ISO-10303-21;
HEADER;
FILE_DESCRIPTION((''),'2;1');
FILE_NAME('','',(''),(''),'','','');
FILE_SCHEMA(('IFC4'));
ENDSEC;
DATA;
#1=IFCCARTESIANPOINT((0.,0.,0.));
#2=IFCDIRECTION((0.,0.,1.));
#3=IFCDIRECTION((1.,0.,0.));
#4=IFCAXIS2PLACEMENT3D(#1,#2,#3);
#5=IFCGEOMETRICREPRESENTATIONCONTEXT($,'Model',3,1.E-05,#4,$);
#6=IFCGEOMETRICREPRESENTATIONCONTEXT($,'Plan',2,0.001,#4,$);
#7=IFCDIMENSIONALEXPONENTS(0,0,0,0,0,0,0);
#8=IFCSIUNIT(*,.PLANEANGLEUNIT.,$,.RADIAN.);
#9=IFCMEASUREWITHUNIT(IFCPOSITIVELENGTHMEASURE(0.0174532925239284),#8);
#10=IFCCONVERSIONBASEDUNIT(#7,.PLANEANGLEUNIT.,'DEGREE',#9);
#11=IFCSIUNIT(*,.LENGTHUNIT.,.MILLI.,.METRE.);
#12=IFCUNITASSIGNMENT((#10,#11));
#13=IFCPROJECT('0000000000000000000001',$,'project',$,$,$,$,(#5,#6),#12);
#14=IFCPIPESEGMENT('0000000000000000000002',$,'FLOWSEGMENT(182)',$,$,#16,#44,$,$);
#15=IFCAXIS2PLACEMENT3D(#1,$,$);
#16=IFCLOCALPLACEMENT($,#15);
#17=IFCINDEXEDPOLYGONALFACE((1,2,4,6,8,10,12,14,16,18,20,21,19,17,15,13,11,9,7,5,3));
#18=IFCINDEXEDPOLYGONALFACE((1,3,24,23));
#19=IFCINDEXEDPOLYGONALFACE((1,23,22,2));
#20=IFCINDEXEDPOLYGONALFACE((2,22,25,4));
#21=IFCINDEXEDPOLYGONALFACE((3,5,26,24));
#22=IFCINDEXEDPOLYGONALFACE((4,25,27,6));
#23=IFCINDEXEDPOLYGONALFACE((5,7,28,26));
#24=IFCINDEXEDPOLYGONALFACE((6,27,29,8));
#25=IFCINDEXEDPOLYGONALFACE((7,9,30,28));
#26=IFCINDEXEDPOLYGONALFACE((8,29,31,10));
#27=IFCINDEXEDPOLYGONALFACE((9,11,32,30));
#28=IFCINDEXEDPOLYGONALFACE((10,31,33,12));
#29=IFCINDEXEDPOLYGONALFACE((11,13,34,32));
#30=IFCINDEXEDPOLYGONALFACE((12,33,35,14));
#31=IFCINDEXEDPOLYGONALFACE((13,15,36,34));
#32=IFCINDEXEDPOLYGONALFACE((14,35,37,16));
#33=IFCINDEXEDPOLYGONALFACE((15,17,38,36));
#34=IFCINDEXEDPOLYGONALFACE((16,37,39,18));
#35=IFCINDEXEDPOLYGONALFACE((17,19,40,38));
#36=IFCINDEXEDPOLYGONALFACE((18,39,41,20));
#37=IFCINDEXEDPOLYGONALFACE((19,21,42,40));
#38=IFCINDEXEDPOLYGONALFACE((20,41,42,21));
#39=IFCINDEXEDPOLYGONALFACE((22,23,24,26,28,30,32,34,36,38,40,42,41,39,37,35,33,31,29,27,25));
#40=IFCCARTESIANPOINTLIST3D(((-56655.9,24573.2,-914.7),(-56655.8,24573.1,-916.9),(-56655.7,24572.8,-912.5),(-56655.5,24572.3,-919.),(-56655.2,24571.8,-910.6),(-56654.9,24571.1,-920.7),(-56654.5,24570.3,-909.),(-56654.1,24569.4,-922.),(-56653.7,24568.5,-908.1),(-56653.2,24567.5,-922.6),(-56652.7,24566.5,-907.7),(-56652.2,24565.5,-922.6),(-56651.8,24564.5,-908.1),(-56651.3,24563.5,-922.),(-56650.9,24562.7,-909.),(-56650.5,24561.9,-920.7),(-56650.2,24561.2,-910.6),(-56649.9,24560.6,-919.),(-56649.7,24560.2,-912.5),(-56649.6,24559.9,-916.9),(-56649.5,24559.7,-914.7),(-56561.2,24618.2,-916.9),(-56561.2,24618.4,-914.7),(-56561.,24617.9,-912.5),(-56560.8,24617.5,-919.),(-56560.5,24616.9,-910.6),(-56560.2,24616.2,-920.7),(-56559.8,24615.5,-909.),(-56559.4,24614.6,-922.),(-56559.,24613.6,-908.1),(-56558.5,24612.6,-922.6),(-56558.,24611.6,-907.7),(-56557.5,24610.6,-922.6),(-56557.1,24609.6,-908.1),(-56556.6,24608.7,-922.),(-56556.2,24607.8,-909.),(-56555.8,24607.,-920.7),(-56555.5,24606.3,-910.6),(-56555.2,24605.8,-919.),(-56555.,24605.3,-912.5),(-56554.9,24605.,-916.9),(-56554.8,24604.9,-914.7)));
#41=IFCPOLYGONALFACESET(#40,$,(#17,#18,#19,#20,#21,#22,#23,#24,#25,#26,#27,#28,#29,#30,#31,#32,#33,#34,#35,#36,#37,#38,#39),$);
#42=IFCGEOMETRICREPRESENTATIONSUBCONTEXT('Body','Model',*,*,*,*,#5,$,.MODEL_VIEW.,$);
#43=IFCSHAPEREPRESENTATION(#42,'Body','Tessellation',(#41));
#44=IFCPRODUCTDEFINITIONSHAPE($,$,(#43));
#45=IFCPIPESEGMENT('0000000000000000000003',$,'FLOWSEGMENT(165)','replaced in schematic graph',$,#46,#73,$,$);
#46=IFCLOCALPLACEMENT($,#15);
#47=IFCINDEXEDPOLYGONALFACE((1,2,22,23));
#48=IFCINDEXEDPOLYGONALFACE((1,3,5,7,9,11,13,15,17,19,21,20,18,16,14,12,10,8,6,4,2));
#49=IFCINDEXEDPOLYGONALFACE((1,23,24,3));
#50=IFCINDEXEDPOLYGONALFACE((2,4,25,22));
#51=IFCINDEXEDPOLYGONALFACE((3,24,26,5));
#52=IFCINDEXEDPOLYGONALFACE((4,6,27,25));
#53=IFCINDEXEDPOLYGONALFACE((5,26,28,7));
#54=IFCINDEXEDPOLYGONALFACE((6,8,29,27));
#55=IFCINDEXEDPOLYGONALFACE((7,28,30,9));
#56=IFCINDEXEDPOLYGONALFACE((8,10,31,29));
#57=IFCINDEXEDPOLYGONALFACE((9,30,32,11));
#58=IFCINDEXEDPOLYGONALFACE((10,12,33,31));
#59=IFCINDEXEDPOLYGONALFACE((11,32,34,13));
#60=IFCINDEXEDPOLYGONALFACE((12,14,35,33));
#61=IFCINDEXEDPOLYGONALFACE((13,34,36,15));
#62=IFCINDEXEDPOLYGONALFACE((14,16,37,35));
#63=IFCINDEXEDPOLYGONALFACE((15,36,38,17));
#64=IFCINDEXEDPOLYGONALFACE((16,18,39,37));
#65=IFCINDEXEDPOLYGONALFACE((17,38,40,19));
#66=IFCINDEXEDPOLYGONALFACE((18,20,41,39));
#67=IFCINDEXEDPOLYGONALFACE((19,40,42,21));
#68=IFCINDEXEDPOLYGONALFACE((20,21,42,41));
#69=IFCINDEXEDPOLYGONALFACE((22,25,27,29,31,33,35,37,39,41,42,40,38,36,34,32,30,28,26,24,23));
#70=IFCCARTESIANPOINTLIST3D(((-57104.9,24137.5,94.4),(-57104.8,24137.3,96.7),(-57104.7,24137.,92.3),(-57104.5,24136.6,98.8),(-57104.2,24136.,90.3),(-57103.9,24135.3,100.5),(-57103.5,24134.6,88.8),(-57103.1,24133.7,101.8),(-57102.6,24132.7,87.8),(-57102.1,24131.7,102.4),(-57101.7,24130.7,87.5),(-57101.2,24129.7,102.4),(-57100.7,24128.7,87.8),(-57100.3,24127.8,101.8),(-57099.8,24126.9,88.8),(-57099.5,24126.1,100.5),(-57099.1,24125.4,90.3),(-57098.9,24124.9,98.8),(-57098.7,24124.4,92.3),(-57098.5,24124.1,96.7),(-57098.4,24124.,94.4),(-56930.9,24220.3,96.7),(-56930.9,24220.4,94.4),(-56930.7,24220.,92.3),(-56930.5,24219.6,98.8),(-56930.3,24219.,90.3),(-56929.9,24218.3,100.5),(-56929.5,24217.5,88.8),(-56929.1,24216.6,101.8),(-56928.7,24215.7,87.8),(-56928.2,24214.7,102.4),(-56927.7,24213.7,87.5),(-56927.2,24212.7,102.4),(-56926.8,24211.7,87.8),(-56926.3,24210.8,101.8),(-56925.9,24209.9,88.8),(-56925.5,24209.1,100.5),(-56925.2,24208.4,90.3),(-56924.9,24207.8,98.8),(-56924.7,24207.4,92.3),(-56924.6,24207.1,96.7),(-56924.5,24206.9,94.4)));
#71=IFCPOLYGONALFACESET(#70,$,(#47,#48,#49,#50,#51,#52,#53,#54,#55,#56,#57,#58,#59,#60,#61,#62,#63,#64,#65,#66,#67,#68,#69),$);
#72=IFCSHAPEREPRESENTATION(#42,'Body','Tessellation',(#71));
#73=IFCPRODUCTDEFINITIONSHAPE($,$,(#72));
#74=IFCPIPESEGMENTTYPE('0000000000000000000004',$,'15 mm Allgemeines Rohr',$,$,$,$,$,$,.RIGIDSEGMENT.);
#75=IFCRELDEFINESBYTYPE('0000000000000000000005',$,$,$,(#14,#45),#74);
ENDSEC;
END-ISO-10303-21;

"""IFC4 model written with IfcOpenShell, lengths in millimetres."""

from ifc_helpers import new_model, entity, si_unit, converted_unit, frame, frame_2d, origin, origin_with_axes, place, context, subcontext, project, circle, extrude, source, transform, mapped, type_object, element, save


model = new_model("IFC4")

# Units and contexts
model_context = context("Model", 3, precision=1e-05, world=origin_with_axes())
plan_context = context("Plan", 2, precision=0.001, world=origin_with_axes())
body_context = subcontext(model_context, "Body", "Model", "MODEL_VIEW")
ifc_project = project(units=[converted_unit("PLANEANGLEUNIT", "DEGREE", entity("IfcPositiveLengthMeasure", 0.0174532925239284), si_unit("PLANEANGLEUNIT", "RADIAN"), dimensions=[0, 0, 0, 0, 0, 0, 0]), si_unit("LENGTHUNIT", "METRE", prefix="MILLI")], contexts=[model_context, plan_context])

# Pipe segments
pipe_segment_type_1 = type_object("IfcPipeSegmentType", Name="15 mm Allgemeines Rohr", PredefinedType="RIGIDSEGMENT")
shared_shape = source(origin(), body_context, "Body", "SweptSolid", [
    extrude(circle(Radius=7.5, at=frame_2d((7.5, 7.5), x_axis=(1.0, 0.0))), frame((0.0, -7.5, -7.5), z_axis=(1.0, 0.0, 0.0), x_axis=(0.0, 1.0, 0.0)), (0.0, 0.0, 1.0), 1.0),
])
placement_1 = place(None, origin_with_axes())
placement_2 = place(placement_1, origin_with_axes())
placement_3 = place(placement_2, frame((0.0, 0.0, -3400.0), z_axis=(0.0, 0.0, 1.0), x_axis=(1.0, 0.0, 0.0)))
pipe_segment_1_placement = place(placement_3, frame((-56558.0, 24611.6, 2484.8), z_axis=(-0.430461, 0.902609, 0.0), x_axis=(-0.902609, -0.430461, 0.0)))
element("IfcPipeSegment", 1, at=pipe_segment_1_placement, type_object=pipe_segment_type_1, Name="FLOWSEGMENT(182)", context=body_context, shape_type="MappedRepresentation", body=[
    mapped(shared_shape, transform((0.0, 0.0, 0.0), x_axis=(1.0, 0.0, 0.0), y_axis=(0.0, 1.0, 0.0), z_axis=(0.0, 0.0, 1.0), scale=104.898581, scale2=1.0, scale3=1.0, uniform=False)),
])
pipe_segment_2_placement = place(placement_3, frame((-57101.7, 24130.7, 3495.0), z_axis=(-0.430461, 0.902609, 0.0), x_axis=(0.902609, 0.430461, 0.0)))
element("IfcPipeSegment", 2, at=pipe_segment_2_placement, type_object=pipe_segment_type_1, Name="FLOWSEGMENT(165)", Description="replaced in schematic graph", context=body_context, shape_type="MappedRepresentation", body=[
    mapped(shared_shape, transform((0.0, 0.0, 0.0), x_axis=(1.0, 0.0, 0.0), y_axis=(0.0, 1.0, 0.0), z_axis=(0.0, 0.0, 1.0), scale=192.697716, scale2=1.0, scale3=1.0, uniform=False)),
])

save(model, "model.ifc")
